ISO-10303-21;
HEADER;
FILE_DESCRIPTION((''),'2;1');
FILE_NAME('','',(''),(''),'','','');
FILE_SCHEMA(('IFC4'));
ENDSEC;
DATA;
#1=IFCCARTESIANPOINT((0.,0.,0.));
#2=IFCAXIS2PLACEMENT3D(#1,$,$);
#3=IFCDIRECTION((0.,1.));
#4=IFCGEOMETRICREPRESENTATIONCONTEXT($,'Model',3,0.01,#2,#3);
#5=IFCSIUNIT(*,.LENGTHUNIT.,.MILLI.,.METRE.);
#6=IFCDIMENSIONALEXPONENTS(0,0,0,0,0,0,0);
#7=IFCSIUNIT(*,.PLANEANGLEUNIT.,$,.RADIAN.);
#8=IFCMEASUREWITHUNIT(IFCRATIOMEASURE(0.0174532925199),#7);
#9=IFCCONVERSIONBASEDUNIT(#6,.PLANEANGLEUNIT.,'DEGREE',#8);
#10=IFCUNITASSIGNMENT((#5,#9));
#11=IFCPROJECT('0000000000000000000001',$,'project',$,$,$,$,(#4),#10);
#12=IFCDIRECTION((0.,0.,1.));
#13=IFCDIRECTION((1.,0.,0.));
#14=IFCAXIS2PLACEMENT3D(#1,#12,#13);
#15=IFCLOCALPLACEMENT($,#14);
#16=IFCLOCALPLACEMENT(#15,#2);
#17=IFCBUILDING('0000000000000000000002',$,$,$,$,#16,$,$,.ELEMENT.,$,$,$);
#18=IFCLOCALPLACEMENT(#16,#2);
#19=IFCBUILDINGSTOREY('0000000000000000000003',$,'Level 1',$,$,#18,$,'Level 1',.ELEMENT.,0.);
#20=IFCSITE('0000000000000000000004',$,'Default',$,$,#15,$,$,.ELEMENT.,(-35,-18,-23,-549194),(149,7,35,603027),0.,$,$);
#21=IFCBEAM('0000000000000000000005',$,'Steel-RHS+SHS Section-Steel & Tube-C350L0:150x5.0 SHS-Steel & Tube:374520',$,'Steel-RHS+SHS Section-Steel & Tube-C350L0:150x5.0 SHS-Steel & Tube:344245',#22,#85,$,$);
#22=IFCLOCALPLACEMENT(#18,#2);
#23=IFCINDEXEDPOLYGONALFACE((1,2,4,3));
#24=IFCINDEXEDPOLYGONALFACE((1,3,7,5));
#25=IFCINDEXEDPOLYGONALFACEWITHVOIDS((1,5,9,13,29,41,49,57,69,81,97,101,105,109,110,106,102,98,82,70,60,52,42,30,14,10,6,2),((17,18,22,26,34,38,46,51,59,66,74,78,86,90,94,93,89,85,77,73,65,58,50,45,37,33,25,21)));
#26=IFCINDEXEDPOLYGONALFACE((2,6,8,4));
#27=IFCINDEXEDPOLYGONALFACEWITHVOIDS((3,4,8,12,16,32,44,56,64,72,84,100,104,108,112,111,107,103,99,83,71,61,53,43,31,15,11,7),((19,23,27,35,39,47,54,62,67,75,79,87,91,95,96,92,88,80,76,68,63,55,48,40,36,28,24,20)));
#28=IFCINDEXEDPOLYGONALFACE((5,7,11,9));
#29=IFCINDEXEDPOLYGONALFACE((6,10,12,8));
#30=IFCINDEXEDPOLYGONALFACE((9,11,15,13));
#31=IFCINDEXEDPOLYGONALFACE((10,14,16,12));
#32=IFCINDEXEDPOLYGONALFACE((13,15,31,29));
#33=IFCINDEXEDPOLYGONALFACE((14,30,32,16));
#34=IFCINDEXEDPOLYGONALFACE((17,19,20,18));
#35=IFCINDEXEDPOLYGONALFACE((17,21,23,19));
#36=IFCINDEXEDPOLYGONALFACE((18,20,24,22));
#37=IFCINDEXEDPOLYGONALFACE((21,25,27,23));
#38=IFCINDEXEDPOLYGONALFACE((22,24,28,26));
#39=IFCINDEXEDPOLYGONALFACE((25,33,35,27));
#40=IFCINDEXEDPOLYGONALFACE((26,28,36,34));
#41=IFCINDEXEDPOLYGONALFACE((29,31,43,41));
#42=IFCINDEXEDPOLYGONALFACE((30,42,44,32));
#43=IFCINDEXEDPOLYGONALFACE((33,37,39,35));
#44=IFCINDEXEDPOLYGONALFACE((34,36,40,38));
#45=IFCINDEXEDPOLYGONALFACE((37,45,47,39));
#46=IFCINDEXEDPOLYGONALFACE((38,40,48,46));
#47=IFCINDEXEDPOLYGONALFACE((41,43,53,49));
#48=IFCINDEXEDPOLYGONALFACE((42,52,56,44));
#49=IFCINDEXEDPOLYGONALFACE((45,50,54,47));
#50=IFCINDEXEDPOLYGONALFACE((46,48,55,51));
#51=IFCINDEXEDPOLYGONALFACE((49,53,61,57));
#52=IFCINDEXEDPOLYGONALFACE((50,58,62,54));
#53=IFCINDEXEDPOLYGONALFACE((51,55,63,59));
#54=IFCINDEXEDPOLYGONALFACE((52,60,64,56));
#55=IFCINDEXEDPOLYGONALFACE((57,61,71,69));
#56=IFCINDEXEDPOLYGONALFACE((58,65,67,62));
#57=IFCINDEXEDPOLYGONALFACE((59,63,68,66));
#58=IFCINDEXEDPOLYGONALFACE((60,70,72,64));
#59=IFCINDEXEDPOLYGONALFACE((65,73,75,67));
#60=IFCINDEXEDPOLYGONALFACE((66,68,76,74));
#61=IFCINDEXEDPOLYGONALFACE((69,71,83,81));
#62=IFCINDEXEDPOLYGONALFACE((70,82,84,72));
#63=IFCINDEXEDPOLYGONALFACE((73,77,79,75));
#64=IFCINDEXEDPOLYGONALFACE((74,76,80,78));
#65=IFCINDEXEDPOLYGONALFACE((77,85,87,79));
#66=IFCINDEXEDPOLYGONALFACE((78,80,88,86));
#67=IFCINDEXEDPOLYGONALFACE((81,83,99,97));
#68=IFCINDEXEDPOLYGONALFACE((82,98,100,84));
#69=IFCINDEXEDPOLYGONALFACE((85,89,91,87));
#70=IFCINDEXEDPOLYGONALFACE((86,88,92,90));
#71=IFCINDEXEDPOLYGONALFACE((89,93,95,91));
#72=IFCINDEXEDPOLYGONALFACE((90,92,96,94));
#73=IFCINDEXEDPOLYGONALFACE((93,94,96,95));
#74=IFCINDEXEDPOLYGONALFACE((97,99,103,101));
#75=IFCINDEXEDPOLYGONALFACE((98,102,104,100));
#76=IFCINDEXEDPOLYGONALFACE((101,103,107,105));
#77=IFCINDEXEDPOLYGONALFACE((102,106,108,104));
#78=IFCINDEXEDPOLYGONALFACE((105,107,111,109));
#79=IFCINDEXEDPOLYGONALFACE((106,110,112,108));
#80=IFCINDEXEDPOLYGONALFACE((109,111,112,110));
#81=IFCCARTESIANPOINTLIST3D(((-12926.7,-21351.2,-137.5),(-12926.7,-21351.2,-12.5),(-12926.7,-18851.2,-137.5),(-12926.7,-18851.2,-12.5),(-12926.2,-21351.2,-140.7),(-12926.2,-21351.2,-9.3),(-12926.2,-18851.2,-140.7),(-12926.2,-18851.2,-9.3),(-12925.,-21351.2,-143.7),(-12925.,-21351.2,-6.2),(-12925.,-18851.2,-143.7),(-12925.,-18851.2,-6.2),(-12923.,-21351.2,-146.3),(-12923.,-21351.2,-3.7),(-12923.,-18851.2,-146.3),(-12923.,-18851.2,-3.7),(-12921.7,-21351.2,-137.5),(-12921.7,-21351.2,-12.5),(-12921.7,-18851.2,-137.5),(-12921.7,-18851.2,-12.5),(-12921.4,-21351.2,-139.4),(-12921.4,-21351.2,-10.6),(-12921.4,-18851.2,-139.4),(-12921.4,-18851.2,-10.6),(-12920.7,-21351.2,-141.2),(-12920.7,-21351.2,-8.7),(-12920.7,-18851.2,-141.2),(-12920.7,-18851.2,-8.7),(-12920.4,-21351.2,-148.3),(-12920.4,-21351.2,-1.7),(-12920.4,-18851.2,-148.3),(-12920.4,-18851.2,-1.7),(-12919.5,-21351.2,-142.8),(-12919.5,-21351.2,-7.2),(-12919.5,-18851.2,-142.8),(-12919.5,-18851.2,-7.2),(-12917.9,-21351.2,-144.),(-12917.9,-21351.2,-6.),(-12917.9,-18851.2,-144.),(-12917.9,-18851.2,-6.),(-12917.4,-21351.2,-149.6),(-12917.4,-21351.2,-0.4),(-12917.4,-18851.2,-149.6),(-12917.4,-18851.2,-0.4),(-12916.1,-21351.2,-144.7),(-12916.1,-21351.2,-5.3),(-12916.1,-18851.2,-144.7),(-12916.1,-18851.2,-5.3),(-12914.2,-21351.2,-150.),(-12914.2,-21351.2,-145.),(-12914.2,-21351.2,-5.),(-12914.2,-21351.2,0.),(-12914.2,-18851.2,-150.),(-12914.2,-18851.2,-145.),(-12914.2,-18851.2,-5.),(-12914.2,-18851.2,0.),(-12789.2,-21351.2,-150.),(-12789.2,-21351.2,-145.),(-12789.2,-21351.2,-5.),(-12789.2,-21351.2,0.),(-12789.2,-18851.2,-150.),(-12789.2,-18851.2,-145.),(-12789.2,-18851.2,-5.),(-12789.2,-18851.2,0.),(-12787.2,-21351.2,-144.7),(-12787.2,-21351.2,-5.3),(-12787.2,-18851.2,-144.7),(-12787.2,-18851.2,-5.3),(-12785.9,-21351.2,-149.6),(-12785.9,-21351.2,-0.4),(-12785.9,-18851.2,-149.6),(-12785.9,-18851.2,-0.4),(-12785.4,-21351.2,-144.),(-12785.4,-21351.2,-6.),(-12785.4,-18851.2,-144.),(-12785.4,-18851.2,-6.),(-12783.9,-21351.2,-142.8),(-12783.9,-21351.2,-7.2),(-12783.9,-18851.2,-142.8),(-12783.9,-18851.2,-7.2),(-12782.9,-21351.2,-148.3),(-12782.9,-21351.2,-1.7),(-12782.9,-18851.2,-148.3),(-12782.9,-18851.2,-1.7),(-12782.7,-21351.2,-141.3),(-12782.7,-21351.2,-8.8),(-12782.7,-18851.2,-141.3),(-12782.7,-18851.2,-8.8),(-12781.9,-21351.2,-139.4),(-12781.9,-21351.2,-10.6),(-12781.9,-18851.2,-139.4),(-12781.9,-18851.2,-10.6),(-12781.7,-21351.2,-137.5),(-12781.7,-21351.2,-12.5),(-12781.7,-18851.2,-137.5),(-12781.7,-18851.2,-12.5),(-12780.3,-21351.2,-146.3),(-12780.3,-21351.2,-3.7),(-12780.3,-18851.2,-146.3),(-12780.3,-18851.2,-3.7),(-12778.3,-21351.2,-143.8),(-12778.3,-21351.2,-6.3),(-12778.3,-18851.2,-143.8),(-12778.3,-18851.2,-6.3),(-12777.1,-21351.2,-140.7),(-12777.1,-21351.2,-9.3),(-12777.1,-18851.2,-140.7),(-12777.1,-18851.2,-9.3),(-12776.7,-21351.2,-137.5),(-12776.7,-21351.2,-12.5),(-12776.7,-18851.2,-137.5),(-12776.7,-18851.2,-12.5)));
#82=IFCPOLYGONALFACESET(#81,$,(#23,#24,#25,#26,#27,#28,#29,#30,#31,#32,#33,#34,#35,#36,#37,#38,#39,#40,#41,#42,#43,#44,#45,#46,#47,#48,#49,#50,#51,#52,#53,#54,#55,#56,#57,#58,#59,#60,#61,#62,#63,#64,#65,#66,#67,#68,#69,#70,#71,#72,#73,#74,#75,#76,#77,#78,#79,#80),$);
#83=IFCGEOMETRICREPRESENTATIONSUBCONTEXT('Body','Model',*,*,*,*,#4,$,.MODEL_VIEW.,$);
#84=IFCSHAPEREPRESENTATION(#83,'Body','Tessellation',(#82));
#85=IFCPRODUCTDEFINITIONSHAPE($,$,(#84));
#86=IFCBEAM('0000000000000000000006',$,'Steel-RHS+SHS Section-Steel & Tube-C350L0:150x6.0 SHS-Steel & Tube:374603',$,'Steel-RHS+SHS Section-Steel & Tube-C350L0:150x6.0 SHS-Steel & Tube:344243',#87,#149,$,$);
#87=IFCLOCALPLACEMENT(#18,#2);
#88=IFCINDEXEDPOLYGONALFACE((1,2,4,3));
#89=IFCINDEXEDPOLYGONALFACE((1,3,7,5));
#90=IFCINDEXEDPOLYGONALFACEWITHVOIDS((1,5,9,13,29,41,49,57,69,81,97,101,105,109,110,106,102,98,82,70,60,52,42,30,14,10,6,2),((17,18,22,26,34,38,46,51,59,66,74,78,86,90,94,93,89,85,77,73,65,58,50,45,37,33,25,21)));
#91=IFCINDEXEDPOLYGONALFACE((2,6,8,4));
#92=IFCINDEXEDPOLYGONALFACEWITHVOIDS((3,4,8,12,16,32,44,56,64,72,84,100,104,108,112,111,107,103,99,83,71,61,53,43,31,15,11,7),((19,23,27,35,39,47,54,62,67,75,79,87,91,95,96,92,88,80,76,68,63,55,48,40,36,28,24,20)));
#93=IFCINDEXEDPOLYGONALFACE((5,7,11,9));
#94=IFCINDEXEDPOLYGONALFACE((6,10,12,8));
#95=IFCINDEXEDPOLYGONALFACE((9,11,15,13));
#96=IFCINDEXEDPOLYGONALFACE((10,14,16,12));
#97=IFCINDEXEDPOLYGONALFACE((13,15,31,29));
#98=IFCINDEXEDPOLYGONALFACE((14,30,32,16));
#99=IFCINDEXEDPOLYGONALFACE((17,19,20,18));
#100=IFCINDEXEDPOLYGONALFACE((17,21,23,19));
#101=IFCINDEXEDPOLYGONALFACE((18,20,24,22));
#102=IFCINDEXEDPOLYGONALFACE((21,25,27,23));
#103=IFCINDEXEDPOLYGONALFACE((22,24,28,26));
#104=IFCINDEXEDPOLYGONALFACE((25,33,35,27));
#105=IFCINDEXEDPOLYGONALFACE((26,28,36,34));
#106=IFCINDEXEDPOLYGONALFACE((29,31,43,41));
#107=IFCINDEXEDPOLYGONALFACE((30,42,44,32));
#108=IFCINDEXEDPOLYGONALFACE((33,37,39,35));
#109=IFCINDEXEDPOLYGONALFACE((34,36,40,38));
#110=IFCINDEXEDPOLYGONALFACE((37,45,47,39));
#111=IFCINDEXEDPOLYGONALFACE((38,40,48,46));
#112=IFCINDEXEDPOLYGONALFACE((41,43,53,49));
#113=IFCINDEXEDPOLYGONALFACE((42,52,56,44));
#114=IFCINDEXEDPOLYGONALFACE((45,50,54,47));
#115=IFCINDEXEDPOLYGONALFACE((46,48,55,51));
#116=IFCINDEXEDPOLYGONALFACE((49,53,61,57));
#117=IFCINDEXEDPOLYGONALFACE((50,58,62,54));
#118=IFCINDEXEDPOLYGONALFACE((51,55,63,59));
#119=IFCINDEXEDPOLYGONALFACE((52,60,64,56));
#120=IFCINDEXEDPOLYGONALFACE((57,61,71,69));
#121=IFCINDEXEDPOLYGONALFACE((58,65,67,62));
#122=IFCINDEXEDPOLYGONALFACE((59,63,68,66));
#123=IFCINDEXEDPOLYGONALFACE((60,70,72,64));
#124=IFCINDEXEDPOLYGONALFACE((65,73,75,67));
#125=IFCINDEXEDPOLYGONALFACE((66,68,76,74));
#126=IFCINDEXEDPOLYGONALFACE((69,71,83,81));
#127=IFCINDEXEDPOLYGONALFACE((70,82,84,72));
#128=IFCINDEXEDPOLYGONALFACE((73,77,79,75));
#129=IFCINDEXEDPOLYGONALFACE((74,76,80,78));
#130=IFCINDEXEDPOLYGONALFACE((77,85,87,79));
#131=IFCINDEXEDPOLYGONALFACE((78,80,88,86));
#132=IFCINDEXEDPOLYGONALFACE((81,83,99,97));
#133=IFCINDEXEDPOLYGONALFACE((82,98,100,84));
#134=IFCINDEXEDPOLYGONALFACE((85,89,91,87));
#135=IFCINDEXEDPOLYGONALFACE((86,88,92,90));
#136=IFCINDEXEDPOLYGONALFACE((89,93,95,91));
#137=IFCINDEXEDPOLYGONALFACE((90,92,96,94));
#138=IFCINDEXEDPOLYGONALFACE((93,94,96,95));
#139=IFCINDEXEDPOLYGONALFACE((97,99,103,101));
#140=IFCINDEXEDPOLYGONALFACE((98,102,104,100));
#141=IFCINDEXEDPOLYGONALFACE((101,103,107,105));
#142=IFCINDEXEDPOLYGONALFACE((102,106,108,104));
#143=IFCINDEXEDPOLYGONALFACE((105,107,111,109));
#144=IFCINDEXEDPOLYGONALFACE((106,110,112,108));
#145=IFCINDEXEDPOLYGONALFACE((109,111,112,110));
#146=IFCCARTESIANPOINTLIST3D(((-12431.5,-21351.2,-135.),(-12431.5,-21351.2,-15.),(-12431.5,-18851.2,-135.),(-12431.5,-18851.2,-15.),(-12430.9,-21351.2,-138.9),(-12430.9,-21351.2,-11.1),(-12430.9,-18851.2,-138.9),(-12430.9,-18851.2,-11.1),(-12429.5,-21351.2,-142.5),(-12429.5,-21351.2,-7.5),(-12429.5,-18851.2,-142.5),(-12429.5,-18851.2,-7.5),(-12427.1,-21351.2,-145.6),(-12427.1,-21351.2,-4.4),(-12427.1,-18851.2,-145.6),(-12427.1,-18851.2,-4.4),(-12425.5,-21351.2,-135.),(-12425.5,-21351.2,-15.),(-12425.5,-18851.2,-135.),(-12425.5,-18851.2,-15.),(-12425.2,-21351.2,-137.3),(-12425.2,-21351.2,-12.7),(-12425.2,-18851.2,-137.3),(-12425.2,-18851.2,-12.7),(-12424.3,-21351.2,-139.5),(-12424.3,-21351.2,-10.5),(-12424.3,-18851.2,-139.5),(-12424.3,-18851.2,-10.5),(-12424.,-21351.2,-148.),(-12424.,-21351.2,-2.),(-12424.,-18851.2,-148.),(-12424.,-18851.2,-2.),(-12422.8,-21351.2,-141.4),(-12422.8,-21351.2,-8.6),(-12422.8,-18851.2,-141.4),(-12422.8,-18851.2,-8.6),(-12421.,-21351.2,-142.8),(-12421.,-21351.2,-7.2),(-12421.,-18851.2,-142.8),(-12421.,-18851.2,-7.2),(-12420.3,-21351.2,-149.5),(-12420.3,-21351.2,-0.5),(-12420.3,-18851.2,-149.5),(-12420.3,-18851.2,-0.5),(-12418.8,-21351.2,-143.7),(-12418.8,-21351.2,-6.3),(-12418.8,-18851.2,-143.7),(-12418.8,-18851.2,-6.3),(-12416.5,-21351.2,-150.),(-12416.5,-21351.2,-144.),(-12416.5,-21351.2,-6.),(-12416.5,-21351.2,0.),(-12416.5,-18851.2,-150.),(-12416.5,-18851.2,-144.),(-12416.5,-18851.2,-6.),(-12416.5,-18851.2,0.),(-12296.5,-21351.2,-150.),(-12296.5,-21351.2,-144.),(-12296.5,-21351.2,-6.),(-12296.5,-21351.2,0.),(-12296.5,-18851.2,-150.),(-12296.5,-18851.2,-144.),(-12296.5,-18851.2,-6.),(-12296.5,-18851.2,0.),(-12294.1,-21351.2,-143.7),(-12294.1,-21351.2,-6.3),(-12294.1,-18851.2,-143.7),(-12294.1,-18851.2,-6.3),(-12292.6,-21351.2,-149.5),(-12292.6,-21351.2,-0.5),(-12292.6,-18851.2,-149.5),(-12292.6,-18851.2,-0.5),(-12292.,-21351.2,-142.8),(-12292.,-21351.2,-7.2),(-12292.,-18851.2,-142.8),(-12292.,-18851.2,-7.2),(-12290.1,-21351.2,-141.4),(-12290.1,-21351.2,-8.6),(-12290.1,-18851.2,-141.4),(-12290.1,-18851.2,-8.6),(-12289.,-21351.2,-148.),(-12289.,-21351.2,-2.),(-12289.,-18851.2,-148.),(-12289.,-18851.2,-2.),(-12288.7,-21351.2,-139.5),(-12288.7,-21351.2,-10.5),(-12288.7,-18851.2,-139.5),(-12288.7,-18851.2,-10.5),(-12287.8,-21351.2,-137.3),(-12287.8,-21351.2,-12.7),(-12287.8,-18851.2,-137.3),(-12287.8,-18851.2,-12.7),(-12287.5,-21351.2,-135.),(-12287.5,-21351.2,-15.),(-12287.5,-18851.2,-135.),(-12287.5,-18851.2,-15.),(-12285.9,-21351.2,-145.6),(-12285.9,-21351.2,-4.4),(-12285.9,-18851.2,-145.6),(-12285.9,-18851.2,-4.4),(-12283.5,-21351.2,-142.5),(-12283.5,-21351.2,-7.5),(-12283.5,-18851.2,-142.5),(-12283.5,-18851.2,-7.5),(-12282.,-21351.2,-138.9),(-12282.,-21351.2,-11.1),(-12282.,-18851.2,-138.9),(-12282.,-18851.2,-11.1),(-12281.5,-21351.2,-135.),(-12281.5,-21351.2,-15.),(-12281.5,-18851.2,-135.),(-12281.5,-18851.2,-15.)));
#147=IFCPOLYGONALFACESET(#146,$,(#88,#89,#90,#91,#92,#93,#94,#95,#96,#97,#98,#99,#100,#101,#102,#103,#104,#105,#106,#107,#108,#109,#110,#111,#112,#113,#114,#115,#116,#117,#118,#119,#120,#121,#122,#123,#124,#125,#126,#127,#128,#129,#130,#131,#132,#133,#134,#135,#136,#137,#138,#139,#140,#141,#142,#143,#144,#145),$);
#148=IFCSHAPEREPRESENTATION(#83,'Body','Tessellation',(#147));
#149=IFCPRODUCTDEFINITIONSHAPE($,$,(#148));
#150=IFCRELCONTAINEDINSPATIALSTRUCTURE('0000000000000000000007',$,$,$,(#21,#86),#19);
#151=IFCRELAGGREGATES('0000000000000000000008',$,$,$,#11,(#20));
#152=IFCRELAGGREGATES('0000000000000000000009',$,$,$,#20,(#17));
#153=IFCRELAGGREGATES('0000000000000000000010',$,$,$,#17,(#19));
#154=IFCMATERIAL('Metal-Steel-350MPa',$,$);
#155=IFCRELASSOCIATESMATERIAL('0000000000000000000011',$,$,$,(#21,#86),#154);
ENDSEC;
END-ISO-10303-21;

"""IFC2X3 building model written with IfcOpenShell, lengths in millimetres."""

from ifc_helpers import new_model, entity, si_unit, converted_unit, direction, frame, frame_2d, origin, origin_with_axes, place, context, subcontext, project, spatial, polyline, circle_curve, parameter, trimmed, segment, composite_curve, outline, extrude, material, element, save


model = new_model("IFC2X3")

# Units and contexts
model_context = context("Model", 3, precision=0.01, world=origin(), true_north=direction((0.0, 1.0)))
body_context = subcontext(model_context, "Body", "Model", "MODEL_VIEW")
ifc_project = project(units=[si_unit("LENGTHUNIT", "METRE", prefix="MILLI"), converted_unit("PLANEANGLEUNIT", "DEGREE", entity("IfcRatioMeasure", 0.0174532925199), si_unit("PLANEANGLEUNIT", "RADIAN"), dimensions=[0, 0, 0, 0, 0, 0, 0])], contexts=[model_context])

# Site, building, storey
site_placement = place(None, origin_with_axes())
site = spatial("IfcSite", under=ifc_project, at=site_placement, Name="Default", CompositionType="ELEMENT", RefLatitude=(-35, -18, -23, -549194), RefLongitude=(149, 7, 35, 603027), RefElevation=0.0)
building_placement = place(site_placement, origin())
building = spatial("IfcBuilding", under=site, at=building_placement, CompositionType="ELEMENT")
storey_placement = place(building_placement, origin())
storey = spatial("IfcBuildingStorey", under=building, at=storey_placement, Name="Level 1", LongName="Level 1", CompositionType="ELEMENT", Elevation=0.0)

# Beams
ifc_material = material(Name="Metal-Steel-350MPa")
beam_1_placement = place(storey_placement, frame((-12851.7, -18851.2, 0.0), z_axis=(0.0, 0.0, 1.0), x_axis=(0.0, -1.0, 0.0)))
element("IfcBeam", 1, at=beam_1_placement, inside=storey, material=ifc_material, Name="Steel-RHS+SHS Section-Steel & Tube-C350L0:150x5.0 SHS-Steel & Tube:374520", ObjectType="Steel-RHS+SHS Section-Steel & Tube-C350L0:150x5.0 SHS-Steel & Tube:344245", context=body_context, shape_type="SweptSolid", body=[
    extrude(outline(composite_curve([segment(trimmed(circle_curve(frame_2d((-62.5, -62.5), x_axis=(1.0, 0.0)), 12.5), [parameter(180.0)], [parameter(270.0)], True, "PARAMETER"), True, "CONTINUOUS"), segment(polyline([(-62.5, -75.0), (62.5, -75.0)]), True, "CONTINUOUS"), segment(trimmed(circle_curve(frame_2d((62.5, -62.5), x_axis=(1.0, 0.0)), 12.5), [parameter(270.0)], [parameter(0.0)], True, "PARAMETER"), True, "CONTINUOUS"), segment(polyline([(75.0, -62.5), (75.0, 62.5)]), True, "CONTINUOUS"), segment(trimmed(circle_curve(frame_2d((62.5, 62.5), x_axis=(1.0, 0.0)), 12.5), [parameter(0.0)], [parameter(90.0)], True, "PARAMETER"), True, "CONTINUOUS"), segment(polyline([(62.5, 75.0), (-62.5, 75.0)]), True, "CONTINUOUS"), segment(trimmed(circle_curve(frame_2d((-62.5, 62.5), x_axis=(1.0, 0.0)), 12.5), [parameter(90.0)], [parameter(180.0)], True, "PARAMETER"), True, "CONTINUOUS"), segment(polyline([(-75.0, 62.5), (-75.0, -62.5)]), True, "CONTINUOUS")], self_intersect=False), holes=[composite_curve([segment(polyline([(62.5, -70.0), (-62.5, -70.0)]), True, "CONTINUOUS"), segment(trimmed(circle_curve(frame_2d((-62.5, -62.5), x_axis=(1.0, 0.0)), 7.5), [parameter(180.0)], [parameter(270.0)], True, "PARAMETER"), False, "CONTINUOUS"), segment(polyline([(-70.0, -62.5), (-70.0, 62.5)]), True, "CONTINUOUS"), segment(trimmed(circle_curve(frame_2d((-62.5, 62.5), x_axis=(1.0, 0.0)), 7.5), [parameter(90.0)], [parameter(180.0)], True, "PARAMETER"), False, "CONTINUOUS"), segment(polyline([(-62.5, 70.0), (62.5, 70.0)]), True, "CONTINUOUS"), segment(trimmed(circle_curve(frame_2d((62.5, 62.5), x_axis=(1.0, 0.0)), 7.5), [parameter(360.0)], [parameter(90.0)], True, "PARAMETER"), False, "CONTINUOUS"), segment(polyline([(70.0, 62.5), (70.0, -62.5)]), True, "CONTINUOUS"), segment(trimmed(circle_curve(frame_2d((62.5, -62.5), x_axis=(1.0, 0.0)), 7.5), [parameter(270.0)], [parameter(0.0)], True, "PARAMETER"), False, "CONTINUOUS")], self_intersect=False)]), frame((0.0, 0.0, -75.0), z_axis=(1.0, 0.0, 0.0), x_axis=(0.0, -1.0, 0.0)), (0.0, 0.0, 1.0), 2500.0),
])
beam_2_placement = place(storey_placement, frame((-12356.5, -18851.2, 0.0), z_axis=(0.0, 0.0, 1.0), x_axis=(0.0, -1.0, 0.0)))
element("IfcBeam", 2, at=beam_2_placement, inside=storey, material=ifc_material, Name="Steel-RHS+SHS Section-Steel & Tube-C350L0:150x6.0 SHS-Steel & Tube:374603", ObjectType="Steel-RHS+SHS Section-Steel & Tube-C350L0:150x6.0 SHS-Steel & Tube:344243", context=body_context, shape_type="SweptSolid", body=[
    extrude(outline(composite_curve([segment(trimmed(circle_curve(frame_2d((-60.0, -60.0), x_axis=(1.0, 0.0)), 15.0), [parameter(180.0)], [parameter(270.0)], True, "PARAMETER"), True, "CONTINUOUS"), segment(polyline([(-60.0, -75.0), (60.0, -75.0)]), True, "CONTINUOUS"), segment(trimmed(circle_curve(frame_2d((60.0, -60.0), x_axis=(1.0, 0.0)), 15.0), [parameter(270.0)], [parameter(0.0)], True, "PARAMETER"), True, "CONTINUOUS"), segment(polyline([(75.0, -60.0), (75.0, 60.0)]), True, "CONTINUOUS"), segment(trimmed(circle_curve(frame_2d((60.0, 60.0), x_axis=(1.0, 0.0)), 15.0), [parameter(0.0)], [parameter(90.0)], True, "PARAMETER"), True, "CONTINUOUS"), segment(polyline([(60.0, 75.0), (-60.0, 75.0)]), True, "CONTINUOUS"), segment(trimmed(circle_curve(frame_2d((-60.0, 60.0), x_axis=(1.0, 0.0)), 15.0), [parameter(90.0)], [parameter(180.0)], True, "PARAMETER"), True, "CONTINUOUS"), segment(polyline([(-75.0, 60.0), (-75.0, -60.0)]), True, "CONTINUOUS")], self_intersect=False), holes=[composite_curve([segment(polyline([(60.0, -69.0), (-60.0, -69.0)]), True, "CONTINUOUS"), segment(trimmed(circle_curve(frame_2d((-60.0, -60.0), x_axis=(1.0, 0.0)), 9.0), [parameter(180.0)], [parameter(270.0)], True, "PARAMETER"), False, "CONTINUOUS"), segment(polyline([(-69.0, -60.0), (-69.0, 60.0)]), True, "CONTINUOUS"), segment(trimmed(circle_curve(frame_2d((-60.0, 60.0), x_axis=(1.0, 0.0)), 9.0), [parameter(90.0)], [parameter(180.0)], True, "PARAMETER"), False, "CONTINUOUS"), segment(polyline([(-60.0, 69.0), (60.0, 69.0)]), True, "CONTINUOUS"), segment(trimmed(circle_curve(frame_2d((60.0, 60.0), x_axis=(1.0, 0.0)), 9.0), [parameter(360.0)], [parameter(90.0)], True, "PARAMETER"), False, "CONTINUOUS"), segment(polyline([(69.0, 60.0), (69.0, -60.0)]), True, "CONTINUOUS"), segment(trimmed(circle_curve(frame_2d((60.0, -60.0), x_axis=(1.0, 0.0)), 9.0), [parameter(270.0)], [parameter(360.0)], True, "PARAMETER"), False, "CONTINUOUS")], self_intersect=False)]), frame((0.0, 0.0, -75.0), z_axis=(1.0, 0.0, 0.0), x_axis=(0.0, -1.0, 0.0)), (0.0, 0.0, 1.0), 2500.0),
])

save(model, "model.ifc")
